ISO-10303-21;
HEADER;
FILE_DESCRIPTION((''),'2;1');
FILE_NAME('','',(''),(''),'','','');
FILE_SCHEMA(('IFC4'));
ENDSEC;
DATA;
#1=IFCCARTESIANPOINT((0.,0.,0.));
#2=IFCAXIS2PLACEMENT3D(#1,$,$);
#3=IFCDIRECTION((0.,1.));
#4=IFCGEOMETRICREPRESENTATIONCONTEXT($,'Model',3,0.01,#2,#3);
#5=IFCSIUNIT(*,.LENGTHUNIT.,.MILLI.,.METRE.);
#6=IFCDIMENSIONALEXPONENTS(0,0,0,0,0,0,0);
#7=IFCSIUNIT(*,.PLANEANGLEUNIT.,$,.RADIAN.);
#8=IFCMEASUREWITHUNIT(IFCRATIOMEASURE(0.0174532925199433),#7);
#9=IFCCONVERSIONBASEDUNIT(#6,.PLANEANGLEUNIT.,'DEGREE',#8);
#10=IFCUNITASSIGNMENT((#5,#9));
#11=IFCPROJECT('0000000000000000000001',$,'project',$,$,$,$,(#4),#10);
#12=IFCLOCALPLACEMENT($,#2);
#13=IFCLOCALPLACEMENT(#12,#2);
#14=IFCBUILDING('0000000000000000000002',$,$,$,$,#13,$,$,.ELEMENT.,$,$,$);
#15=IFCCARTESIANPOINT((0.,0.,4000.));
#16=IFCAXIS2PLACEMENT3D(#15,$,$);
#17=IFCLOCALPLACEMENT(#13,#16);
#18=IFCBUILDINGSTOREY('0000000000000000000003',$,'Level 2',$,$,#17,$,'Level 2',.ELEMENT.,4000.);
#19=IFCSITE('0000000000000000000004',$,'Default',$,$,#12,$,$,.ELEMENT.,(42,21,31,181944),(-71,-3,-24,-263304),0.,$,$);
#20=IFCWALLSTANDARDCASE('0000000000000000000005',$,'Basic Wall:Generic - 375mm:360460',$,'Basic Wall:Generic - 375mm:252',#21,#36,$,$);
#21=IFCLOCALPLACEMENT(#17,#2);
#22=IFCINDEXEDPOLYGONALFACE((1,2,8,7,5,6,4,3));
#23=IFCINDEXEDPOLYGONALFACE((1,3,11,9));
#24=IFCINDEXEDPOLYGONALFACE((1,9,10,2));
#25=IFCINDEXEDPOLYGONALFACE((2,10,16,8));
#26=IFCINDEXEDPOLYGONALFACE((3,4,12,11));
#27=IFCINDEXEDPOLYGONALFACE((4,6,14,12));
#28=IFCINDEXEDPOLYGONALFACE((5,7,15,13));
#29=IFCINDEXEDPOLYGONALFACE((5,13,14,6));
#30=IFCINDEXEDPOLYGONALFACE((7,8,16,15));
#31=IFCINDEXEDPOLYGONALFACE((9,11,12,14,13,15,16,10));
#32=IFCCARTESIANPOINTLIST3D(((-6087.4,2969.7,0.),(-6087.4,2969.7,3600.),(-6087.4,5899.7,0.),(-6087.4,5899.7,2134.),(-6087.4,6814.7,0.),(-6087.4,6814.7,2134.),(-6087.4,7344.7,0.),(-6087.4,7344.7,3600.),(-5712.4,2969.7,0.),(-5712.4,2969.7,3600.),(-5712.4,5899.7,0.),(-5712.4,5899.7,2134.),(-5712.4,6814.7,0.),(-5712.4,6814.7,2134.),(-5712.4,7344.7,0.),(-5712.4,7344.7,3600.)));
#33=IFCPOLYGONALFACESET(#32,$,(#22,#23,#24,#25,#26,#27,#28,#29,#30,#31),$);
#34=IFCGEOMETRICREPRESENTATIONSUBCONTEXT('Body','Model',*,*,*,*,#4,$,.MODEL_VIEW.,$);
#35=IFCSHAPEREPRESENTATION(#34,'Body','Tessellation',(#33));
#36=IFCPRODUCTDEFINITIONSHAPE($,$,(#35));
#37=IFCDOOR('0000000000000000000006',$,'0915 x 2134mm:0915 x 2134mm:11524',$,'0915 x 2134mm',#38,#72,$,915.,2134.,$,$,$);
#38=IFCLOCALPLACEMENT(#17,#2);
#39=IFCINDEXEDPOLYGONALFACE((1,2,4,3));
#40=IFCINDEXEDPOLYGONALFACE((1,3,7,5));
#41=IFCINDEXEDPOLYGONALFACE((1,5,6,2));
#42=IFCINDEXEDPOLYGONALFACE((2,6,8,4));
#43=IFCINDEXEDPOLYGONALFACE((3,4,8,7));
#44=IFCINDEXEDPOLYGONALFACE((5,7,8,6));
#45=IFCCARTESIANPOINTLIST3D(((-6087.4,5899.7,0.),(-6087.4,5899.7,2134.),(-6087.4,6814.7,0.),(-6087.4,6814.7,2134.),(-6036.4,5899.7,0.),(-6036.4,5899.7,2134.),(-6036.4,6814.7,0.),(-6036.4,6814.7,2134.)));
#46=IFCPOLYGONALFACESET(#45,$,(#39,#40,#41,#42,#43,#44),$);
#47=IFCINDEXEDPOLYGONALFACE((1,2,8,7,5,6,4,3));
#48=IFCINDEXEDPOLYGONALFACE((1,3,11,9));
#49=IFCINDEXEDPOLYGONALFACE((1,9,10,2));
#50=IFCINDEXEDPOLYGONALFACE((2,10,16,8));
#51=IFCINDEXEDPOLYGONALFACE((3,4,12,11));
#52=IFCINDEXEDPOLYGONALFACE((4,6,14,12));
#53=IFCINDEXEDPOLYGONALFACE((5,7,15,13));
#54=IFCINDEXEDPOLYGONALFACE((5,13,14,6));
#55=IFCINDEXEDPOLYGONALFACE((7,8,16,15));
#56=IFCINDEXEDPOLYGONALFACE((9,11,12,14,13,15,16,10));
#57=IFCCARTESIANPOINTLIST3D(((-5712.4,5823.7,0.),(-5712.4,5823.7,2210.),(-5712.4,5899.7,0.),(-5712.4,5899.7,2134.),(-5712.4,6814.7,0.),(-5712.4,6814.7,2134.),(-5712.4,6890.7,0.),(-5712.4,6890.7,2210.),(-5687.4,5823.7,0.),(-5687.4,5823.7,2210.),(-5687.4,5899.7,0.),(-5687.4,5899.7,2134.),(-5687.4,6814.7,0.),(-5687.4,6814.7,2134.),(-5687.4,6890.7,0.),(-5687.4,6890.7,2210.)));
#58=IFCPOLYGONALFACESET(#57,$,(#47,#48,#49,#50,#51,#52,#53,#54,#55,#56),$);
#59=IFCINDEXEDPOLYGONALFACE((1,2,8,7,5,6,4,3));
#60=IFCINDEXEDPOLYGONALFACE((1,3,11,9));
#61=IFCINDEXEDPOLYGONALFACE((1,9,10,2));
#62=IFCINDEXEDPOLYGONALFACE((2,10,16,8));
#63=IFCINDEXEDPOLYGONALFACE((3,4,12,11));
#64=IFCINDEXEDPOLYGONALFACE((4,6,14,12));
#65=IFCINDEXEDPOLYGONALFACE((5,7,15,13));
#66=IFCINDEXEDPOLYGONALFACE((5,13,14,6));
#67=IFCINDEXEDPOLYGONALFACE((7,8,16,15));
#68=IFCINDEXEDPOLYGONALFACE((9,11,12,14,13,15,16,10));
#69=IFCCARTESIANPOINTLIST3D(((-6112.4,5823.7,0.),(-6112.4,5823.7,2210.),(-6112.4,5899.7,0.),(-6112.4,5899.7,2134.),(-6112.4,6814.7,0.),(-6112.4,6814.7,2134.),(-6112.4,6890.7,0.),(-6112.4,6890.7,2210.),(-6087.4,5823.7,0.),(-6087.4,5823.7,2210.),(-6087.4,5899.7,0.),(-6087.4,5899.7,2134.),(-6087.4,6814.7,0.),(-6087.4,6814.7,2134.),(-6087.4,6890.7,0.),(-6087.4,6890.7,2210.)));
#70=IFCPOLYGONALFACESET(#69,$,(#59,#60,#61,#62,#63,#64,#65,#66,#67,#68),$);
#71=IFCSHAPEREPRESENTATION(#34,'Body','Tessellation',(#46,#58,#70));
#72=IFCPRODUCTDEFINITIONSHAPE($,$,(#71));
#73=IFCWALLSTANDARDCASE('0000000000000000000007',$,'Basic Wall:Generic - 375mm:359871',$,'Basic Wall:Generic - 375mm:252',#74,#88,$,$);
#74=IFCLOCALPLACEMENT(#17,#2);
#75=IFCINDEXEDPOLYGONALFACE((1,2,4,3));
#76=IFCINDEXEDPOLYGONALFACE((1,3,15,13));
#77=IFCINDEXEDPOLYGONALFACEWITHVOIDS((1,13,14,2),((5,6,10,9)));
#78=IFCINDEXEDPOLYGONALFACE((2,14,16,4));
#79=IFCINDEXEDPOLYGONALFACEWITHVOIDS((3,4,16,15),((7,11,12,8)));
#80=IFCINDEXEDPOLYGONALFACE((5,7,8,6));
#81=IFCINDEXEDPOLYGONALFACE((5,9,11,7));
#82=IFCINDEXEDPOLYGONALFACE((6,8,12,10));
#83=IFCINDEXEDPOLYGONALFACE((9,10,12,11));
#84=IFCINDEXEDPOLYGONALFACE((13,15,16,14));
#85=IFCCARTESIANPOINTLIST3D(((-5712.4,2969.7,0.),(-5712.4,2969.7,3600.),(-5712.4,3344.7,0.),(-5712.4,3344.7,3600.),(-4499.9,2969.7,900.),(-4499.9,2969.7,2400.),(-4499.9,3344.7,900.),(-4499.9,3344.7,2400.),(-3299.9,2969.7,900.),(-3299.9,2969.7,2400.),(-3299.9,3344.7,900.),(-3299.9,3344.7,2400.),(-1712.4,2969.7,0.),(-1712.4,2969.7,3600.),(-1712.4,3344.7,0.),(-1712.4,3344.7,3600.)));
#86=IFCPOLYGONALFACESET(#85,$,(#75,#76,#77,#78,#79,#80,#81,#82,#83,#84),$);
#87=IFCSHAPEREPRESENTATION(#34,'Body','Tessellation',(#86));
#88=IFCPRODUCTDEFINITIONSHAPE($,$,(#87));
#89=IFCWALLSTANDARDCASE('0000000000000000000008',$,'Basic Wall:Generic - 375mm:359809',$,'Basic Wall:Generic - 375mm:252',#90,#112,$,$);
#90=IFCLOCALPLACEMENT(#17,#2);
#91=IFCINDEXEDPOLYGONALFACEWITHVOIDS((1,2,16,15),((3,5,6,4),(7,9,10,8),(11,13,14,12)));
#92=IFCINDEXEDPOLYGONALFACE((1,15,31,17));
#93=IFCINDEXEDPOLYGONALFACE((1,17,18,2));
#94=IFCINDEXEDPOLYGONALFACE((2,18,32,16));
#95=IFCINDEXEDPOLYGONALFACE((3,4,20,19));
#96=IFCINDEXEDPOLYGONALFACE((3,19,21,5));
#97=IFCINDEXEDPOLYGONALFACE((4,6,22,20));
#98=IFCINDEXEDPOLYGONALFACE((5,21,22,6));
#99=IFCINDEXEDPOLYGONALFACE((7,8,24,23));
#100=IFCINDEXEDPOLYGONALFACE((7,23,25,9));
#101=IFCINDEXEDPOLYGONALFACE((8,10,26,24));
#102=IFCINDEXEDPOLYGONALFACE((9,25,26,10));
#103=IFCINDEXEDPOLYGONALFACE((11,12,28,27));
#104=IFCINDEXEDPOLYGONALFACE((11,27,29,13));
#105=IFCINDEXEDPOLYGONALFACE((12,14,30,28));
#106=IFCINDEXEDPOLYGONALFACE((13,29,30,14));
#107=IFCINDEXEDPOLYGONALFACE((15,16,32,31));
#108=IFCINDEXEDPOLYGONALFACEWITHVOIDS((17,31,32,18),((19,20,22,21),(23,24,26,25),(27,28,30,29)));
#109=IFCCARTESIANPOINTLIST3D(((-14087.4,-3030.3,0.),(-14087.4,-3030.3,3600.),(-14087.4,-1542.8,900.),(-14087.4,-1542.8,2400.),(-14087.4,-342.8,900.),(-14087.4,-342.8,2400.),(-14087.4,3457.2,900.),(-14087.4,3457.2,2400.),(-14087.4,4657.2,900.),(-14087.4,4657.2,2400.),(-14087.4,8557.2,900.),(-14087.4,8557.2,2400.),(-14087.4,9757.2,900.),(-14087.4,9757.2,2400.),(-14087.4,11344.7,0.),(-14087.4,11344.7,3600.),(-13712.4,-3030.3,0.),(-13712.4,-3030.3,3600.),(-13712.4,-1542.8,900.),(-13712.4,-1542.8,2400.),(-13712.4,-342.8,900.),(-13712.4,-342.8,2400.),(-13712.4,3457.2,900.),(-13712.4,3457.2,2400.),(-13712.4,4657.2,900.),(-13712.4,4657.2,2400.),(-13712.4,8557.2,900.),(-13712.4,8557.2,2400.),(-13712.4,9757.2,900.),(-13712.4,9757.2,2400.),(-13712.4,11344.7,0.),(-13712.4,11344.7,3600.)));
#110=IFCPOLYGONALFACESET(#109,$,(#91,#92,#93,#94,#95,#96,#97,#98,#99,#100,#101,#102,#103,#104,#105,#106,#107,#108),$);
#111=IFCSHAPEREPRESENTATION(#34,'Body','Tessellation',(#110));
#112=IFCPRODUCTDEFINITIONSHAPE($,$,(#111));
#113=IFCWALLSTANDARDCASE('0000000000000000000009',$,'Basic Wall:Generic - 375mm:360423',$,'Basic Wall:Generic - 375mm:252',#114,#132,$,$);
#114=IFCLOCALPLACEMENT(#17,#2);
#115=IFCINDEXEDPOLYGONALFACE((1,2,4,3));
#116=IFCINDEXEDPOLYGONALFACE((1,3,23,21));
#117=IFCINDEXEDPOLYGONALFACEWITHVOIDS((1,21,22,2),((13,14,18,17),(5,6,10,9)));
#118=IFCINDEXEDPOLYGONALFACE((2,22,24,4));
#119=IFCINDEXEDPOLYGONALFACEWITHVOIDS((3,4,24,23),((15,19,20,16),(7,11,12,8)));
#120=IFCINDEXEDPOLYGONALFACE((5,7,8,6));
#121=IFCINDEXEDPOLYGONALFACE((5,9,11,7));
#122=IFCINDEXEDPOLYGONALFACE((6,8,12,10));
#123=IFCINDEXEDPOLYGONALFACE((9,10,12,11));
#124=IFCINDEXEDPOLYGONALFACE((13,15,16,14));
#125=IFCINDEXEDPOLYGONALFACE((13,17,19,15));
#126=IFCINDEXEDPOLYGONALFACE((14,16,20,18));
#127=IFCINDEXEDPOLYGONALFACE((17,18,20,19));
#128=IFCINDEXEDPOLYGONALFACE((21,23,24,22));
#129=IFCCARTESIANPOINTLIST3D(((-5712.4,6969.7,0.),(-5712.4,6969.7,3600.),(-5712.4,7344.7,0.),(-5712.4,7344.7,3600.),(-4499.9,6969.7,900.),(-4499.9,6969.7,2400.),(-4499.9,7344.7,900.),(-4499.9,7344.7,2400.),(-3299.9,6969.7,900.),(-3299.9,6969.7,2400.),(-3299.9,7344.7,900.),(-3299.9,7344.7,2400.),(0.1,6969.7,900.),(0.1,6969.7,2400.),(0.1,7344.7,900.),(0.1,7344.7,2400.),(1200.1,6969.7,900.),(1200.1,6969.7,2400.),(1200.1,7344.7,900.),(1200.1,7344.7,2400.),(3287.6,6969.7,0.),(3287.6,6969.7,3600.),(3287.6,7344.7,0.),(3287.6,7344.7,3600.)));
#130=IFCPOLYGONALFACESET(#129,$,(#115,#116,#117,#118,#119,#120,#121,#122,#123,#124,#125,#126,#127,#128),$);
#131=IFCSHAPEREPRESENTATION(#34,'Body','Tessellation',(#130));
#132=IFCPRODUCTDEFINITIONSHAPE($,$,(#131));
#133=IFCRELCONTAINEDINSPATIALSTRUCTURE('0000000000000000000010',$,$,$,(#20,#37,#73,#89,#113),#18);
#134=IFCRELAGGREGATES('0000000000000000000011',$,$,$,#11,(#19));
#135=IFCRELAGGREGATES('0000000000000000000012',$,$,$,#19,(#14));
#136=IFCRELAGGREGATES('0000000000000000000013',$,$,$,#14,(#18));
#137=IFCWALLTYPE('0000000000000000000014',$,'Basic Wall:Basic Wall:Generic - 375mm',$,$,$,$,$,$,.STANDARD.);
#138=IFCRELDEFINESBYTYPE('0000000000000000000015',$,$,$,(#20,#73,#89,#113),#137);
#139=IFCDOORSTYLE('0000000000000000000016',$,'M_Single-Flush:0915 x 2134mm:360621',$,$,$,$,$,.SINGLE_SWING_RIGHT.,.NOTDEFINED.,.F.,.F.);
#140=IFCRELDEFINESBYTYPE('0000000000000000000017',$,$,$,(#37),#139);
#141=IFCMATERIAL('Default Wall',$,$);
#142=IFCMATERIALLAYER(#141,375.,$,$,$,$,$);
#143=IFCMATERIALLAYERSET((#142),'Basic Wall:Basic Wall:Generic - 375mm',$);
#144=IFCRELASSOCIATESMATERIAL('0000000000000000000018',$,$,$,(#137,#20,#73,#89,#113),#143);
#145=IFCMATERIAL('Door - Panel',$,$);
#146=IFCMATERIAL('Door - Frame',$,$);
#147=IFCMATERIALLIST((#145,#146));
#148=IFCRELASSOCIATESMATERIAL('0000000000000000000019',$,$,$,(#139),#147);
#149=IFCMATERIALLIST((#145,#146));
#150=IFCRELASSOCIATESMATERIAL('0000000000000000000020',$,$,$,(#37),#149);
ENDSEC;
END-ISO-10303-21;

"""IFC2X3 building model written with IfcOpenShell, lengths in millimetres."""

from ifc_helpers import new_model, entity, si_unit, converted_unit, direction, frame, frame_2d, origin, origin_2d_with_axis, place, context, subcontext, project, spatial, polyline, rectangle, outline, extrude, source, transform, mapped, material, material_list, layer, layer_set, layer_usage, type_object, type_shapes, element, fill, save


model = new_model("IFC2X3")

# Units and contexts
model_context = context("Model", 3, precision=0.01, world=origin(), true_north=direction((0.0, 1.0)))
body_context = subcontext(model_context, "Body", "Model", "MODEL_VIEW")
ifc_project = project(units=[si_unit("LENGTHUNIT", "METRE", prefix="MILLI"), converted_unit("PLANEANGLEUNIT", "DEGREE", entity("IfcRatioMeasure", 0.0174532925199433), si_unit("PLANEANGLEUNIT", "RADIAN"), dimensions=[0, 0, 0, 0, 0, 0, 0])], contexts=[model_context])

# Site, building, storey
site_placement = place(None, origin())
site = spatial("IfcSite", under=ifc_project, at=site_placement, Name="Default", CompositionType="ELEMENT", RefLatitude=(42, 21, 31, 181944), RefLongitude=(-71, -3, -24, -263304), RefElevation=0.0)
building_placement = place(site_placement, origin())
building = spatial("IfcBuilding", under=site, at=building_placement, CompositionType="ELEMENT")
storey_placement = place(building_placement, frame((0.0, 0.0, 4000.0)))
storey = spatial("IfcBuildingStorey", under=building, at=storey_placement, Name="Level 2", LongName="Level 2", CompositionType="ELEMENT", Elevation=4000.0)

# Wall, opening, door
ifc_material_1 = material(Name="Default Wall")
ifc_layer_1 = layer(ifc_material_1, 375.0)
ifc_layer_set_1 = layer_set([ifc_layer_1], Name="Basic Wall:Basic Wall:Generic - 375mm")
ifc_layer_usage_1 = layer_usage(ifc_layer_set_1, "AXIS2", "NEGATIVE", 187.5)
wall_type_1 = type_object("IfcWallType", Name="Basic Wall:Basic Wall:Generic - 375mm", PredefinedType="STANDARD", material=ifc_layer_set_1)
wall_1_placement = place(storey_placement, frame((-5899.9, 2969.7, 0.0), z_axis=(0.0, 0.0, 1.0), x_axis=(0.0, 1.0, 0.0)))
wall_1 = element("IfcWallStandardCase", 1, at=wall_1_placement, inside=storey, type_object=wall_type_1, material=ifc_layer_usage_1, Name="Basic Wall:Generic - 375mm:360460", ObjectType="Basic Wall:Generic - 375mm:252", context=body_context, shape_type="SweptSolid", body=[
    extrude(rectangle(XDim=4375.0, YDim=375.0, at=frame_2d((2187.5, 0.0), x_axis=(-1.0, 0.0))), origin(), (0.0, 0.0, 1.0), 3600.0),
])
opening_1_placement = place(wall_1_placement, frame((-2969.7, -5899.9, 0.0), z_axis=(0.0, 0.0, 1.0), x_axis=(0.0, -1.0, 0.0)))
opening_1 = element("IfcOpeningElement", 2, at=opening_1_placement, cuts=wall_1, ObjectType="Opening", context=body_context, shape_type="SweptSolid", body=[
    extrude(rectangle(XDim=2134.0, YDim=915.0, at=origin_2d_with_axis()), frame((-5708.7, 6357.2, 1067.0), z_axis=(-1.0, 0.0, 0.0), x_axis=(0.0, 0.0, -1.0)), (0.0, 0.0, 1.0), 382.5),
])
ifc_material_2 = material(Name="Door - Panel")
ifc_material_3 = material(Name="Door - Frame")
ifc_material_list_1 = material_list([ifc_material_2, ifc_material_3])
ifc_material_list_2 = material_list([ifc_material_2, ifc_material_3])
door_style_1 = type_object("IfcDoorStyle", Name="M_Single-Flush:0915 x 2134mm:360621", ConstructionType="NOTDEFINED", OperationType="SINGLE_SWING_RIGHT", ParameterTakesPrecedence=False, Sizeable=False, material=ifc_material_list_2)
shared_shape_1 = source(origin(), body_context, "Body", "SweptSolid", [
    extrude(rectangle(XDim=915.0, YDim=51.0, at=origin_2d_with_axis()), frame((457.5, -29.3, 0.0), z_axis=(0.0, 0.0, 1.0), x_axis=(-1.0, 0.0, 0.0)), (0.0, 0.0, 1.0), 2134.0),
    extrude(outline(polyline([(-533.5, -1086.0), (-457.5, -1086.0), (-457.5, 1048.0), (457.5, 1048.0), (457.5, -1086.0), (533.5, -1086.0), (533.5, 1124.0), (-533.5, 1124.0), (-533.5, -1086.0)])), frame((457.5, -403.7, 1086.0), z_axis=(0.0, 1.0, 0.0), x_axis=(-1.0, 0.0, 0.0)), (0.0, 0.0, 1.0), 25.0),
    extrude(outline(polyline([(-1124.0, -533.5), (1086.0, -533.5), (1086.0, -457.5), (-1048.0, -457.5), (-1048.0, 457.5), (1086.0, 457.5), (1086.0, 533.5), (-1124.0, 533.5), (-1124.0, -533.5)])), frame((457.5, -3.7, 1086.0), z_axis=(0.0, 1.0, 0.0), x_axis=(0.0, 0.0, -1.0)), (0.0, 0.0, 1.0), 25.0),
])
type_shapes(door_style_1, [shared_shape_1])
door_1_placement = place(opening_1_placement, frame((-6091.2, 5899.7, 0.0), z_axis=(0.0, 0.0, 1.0), x_axis=(0.0, 1.0, 0.0)))
door_1 = element("IfcDoor", 3, at=door_1_placement, inside=storey, type_object=door_style_1, material=ifc_material_list_1, Name="0915 x 2134mm:0915 x 2134mm:11524", ObjectType="0915 x 2134mm", OverallHeight=915.0, OverallWidth=2134.0, context=body_context, shape_type="MappedRepresentation", body=[
    mapped(shared_shape_1, transform((0.0, 0.0, 0.0), scale=1.0)),
])
fill(opening_1, door_1)

# Wall, opening
ifc_layer_usage_2 = layer_usage(ifc_layer_set_1, "AXIS2", "NEGATIVE", 187.5)
wall_2_placement = place(storey_placement, frame((-1712.4, 3157.2, 0.0), z_axis=(0.0, 0.0, 1.0), x_axis=(-1.0, 0.0, 0.0)))
wall_2 = element("IfcWallStandardCase", 4, at=wall_2_placement, inside=storey, type_object=wall_type_1, material=ifc_layer_usage_2, Name="Basic Wall:Generic - 375mm:359871", ObjectType="Basic Wall:Generic - 375mm:252", context=body_context, shape_type="SweptSolid", body=[
    extrude(rectangle(XDim=4000.0, YDim=375.0, at=frame_2d((2000.0, 0.0), x_axis=(-1.0, 0.0))), origin(), (0.0, 0.0, 1.0), 3600.0),
])
opening_2_placement = place(wall_2_placement, frame((-1712.4, 3157.2, 0.0), z_axis=(0.0, 0.0, 1.0), x_axis=(-1.0, 0.0, 0.0)))
element("IfcOpeningElement", 5, at=opening_2_placement, cuts=wall_2, ObjectType="Opening", context=body_context, shape_type="SweptSolid", body=[
    extrude(rectangle(XDim=1500.0, YDim=1200.0, at=frame_2d((0.0, 0.0), x_axis=(0.0, 1.0))), frame((-3899.9, 3348.4, 1650.0), z_axis=(0.0, -1.0, 0.0), x_axis=(1.0, 0.0, 0.0)), (0.0, 0.0, 1.0), 382.5),
])

# Walls, openings
ifc_layer_usage_3 = layer_usage(ifc_layer_set_1, "AXIS2", "NEGATIVE", 187.5)
wall_3_placement = place(storey_placement, frame((-13899.9, 11344.7, 0.0), z_axis=(0.0, 0.0, 1.0), x_axis=(0.0, -1.0, 0.0)))
wall_3 = element("IfcWallStandardCase", 6, at=wall_3_placement, inside=storey, type_object=wall_type_1, material=ifc_layer_usage_3, Name="Basic Wall:Generic - 375mm:359809", ObjectType="Basic Wall:Generic - 375mm:252", context=body_context, shape_type="SweptSolid", body=[
    extrude(rectangle(XDim=14375.0, YDim=375.0, at=frame_2d((7187.5, 0.0), x_axis=(-1.0, 0.0))), origin(), (0.0, 0.0, 1.0), 3600.0),
])
opening_3_placement = place(wall_3_placement, frame((11344.7, 13899.9, 0.0), z_axis=(0.0, 0.0, 1.0), x_axis=(0.0, 1.0, 0.0)))
element("IfcOpeningElement", 7, at=opening_3_placement, cuts=wall_3, ObjectType="Opening", context=body_context, shape_type="SweptSolid", body=[
    extrude(rectangle(XDim=1500.0, YDim=1200.0, at=frame_2d((0.0, 0.0), x_axis=(0.0, 1.0))), frame((-14091.2, 9157.2, 1650.0), z_axis=(1.0, 0.0, 0.0), x_axis=(0.0, 1.0, 0.0)), (0.0, 0.0, 1.0), 382.5),
])
opening_4_placement = place(wall_3_placement, frame((11344.7, 13899.9, 0.0), z_axis=(0.0, 0.0, 1.0), x_axis=(0.0, 1.0, 0.0)))
element("IfcOpeningElement", 8, at=opening_4_placement, cuts=wall_3, ObjectType="Opening", context=body_context, shape_type="SweptSolid", body=[
    extrude(rectangle(XDim=1500.0, YDim=1200.0, at=frame_2d((0.0, 0.0), x_axis=(0.0, 1.0))), frame((-14091.2, 4057.2, 1650.0), z_axis=(1.0, 0.0, 0.0), x_axis=(0.0, 1.0, 0.0)), (0.0, 0.0, 1.0), 382.5),
])
opening_5_placement = place(wall_3_placement, frame((11344.7, 13899.9, 0.0), z_axis=(0.0, 0.0, 1.0), x_axis=(0.0, 1.0, 0.0)))
element("IfcOpeningElement", 9, at=opening_5_placement, cuts=wall_3, ObjectType="Opening", context=body_context, shape_type="SweptSolid", body=[
    extrude(rectangle(XDim=1500.0, YDim=1200.0, at=frame_2d((0.0, 0.0), x_axis=(0.0, 1.0))), frame((-14091.2, -942.8, 1650.0), z_axis=(1.0, 0.0, 0.0), x_axis=(0.0, 1.0, 0.0)), (0.0, 0.0, 1.0), 382.5),
])
ifc_layer_usage_4 = layer_usage(ifc_layer_set_1, "AXIS2", "NEGATIVE", 187.5)
wall_4_placement = place(storey_placement, frame((-5712.4, 7157.2, 0.0)))
wall_4 = element("IfcWallStandardCase", 10, at=wall_4_placement, inside=storey, type_object=wall_type_1, material=ifc_layer_usage_4, Name="Basic Wall:Generic - 375mm:360423", ObjectType="Basic Wall:Generic - 375mm:252", context=body_context, shape_type="SweptSolid", body=[
    extrude(rectangle(XDim=9000.0, YDim=375.0, at=frame_2d((4500.0, 0.0), x_axis=(-1.0, 0.0))), origin(), (0.0, 0.0, 1.0), 3600.0),
])
opening_6_placement = place(wall_4_placement, frame((5712.4, -7157.2, 0.0)))
element("IfcOpeningElement", 11, at=opening_6_placement, cuts=wall_4, ObjectType="Opening", context=body_context, shape_type="SweptSolid", body=[
    extrude(rectangle(XDim=1500.0, YDim=1200.0, at=frame_2d((0.0, 0.0), x_axis=(0.0, 1.0))), frame((-3899.9, 6965.9, 1650.0), z_axis=(0.0, 1.0, 0.0), x_axis=(-1.0, 0.0, 0.0)), (0.0, 0.0, 1.0), 382.5),
])
opening_7_placement = place(wall_4_placement, frame((5712.4, -7157.2, 0.0)))
element("IfcOpeningElement", 12, at=opening_7_placement, cuts=wall_4, ObjectType="Opening", context=body_context, shape_type="SweptSolid", body=[
    extrude(rectangle(XDim=1500.0, YDim=1200.0, at=frame_2d((0.0, 0.0), x_axis=(0.0, 1.0))), frame((600.1, 6965.9, 1650.0), z_axis=(0.0, 1.0, 0.0), x_axis=(-1.0, 0.0, 0.0)), (0.0, 0.0, 1.0), 382.5),
])

save(model, "model.ifc")
